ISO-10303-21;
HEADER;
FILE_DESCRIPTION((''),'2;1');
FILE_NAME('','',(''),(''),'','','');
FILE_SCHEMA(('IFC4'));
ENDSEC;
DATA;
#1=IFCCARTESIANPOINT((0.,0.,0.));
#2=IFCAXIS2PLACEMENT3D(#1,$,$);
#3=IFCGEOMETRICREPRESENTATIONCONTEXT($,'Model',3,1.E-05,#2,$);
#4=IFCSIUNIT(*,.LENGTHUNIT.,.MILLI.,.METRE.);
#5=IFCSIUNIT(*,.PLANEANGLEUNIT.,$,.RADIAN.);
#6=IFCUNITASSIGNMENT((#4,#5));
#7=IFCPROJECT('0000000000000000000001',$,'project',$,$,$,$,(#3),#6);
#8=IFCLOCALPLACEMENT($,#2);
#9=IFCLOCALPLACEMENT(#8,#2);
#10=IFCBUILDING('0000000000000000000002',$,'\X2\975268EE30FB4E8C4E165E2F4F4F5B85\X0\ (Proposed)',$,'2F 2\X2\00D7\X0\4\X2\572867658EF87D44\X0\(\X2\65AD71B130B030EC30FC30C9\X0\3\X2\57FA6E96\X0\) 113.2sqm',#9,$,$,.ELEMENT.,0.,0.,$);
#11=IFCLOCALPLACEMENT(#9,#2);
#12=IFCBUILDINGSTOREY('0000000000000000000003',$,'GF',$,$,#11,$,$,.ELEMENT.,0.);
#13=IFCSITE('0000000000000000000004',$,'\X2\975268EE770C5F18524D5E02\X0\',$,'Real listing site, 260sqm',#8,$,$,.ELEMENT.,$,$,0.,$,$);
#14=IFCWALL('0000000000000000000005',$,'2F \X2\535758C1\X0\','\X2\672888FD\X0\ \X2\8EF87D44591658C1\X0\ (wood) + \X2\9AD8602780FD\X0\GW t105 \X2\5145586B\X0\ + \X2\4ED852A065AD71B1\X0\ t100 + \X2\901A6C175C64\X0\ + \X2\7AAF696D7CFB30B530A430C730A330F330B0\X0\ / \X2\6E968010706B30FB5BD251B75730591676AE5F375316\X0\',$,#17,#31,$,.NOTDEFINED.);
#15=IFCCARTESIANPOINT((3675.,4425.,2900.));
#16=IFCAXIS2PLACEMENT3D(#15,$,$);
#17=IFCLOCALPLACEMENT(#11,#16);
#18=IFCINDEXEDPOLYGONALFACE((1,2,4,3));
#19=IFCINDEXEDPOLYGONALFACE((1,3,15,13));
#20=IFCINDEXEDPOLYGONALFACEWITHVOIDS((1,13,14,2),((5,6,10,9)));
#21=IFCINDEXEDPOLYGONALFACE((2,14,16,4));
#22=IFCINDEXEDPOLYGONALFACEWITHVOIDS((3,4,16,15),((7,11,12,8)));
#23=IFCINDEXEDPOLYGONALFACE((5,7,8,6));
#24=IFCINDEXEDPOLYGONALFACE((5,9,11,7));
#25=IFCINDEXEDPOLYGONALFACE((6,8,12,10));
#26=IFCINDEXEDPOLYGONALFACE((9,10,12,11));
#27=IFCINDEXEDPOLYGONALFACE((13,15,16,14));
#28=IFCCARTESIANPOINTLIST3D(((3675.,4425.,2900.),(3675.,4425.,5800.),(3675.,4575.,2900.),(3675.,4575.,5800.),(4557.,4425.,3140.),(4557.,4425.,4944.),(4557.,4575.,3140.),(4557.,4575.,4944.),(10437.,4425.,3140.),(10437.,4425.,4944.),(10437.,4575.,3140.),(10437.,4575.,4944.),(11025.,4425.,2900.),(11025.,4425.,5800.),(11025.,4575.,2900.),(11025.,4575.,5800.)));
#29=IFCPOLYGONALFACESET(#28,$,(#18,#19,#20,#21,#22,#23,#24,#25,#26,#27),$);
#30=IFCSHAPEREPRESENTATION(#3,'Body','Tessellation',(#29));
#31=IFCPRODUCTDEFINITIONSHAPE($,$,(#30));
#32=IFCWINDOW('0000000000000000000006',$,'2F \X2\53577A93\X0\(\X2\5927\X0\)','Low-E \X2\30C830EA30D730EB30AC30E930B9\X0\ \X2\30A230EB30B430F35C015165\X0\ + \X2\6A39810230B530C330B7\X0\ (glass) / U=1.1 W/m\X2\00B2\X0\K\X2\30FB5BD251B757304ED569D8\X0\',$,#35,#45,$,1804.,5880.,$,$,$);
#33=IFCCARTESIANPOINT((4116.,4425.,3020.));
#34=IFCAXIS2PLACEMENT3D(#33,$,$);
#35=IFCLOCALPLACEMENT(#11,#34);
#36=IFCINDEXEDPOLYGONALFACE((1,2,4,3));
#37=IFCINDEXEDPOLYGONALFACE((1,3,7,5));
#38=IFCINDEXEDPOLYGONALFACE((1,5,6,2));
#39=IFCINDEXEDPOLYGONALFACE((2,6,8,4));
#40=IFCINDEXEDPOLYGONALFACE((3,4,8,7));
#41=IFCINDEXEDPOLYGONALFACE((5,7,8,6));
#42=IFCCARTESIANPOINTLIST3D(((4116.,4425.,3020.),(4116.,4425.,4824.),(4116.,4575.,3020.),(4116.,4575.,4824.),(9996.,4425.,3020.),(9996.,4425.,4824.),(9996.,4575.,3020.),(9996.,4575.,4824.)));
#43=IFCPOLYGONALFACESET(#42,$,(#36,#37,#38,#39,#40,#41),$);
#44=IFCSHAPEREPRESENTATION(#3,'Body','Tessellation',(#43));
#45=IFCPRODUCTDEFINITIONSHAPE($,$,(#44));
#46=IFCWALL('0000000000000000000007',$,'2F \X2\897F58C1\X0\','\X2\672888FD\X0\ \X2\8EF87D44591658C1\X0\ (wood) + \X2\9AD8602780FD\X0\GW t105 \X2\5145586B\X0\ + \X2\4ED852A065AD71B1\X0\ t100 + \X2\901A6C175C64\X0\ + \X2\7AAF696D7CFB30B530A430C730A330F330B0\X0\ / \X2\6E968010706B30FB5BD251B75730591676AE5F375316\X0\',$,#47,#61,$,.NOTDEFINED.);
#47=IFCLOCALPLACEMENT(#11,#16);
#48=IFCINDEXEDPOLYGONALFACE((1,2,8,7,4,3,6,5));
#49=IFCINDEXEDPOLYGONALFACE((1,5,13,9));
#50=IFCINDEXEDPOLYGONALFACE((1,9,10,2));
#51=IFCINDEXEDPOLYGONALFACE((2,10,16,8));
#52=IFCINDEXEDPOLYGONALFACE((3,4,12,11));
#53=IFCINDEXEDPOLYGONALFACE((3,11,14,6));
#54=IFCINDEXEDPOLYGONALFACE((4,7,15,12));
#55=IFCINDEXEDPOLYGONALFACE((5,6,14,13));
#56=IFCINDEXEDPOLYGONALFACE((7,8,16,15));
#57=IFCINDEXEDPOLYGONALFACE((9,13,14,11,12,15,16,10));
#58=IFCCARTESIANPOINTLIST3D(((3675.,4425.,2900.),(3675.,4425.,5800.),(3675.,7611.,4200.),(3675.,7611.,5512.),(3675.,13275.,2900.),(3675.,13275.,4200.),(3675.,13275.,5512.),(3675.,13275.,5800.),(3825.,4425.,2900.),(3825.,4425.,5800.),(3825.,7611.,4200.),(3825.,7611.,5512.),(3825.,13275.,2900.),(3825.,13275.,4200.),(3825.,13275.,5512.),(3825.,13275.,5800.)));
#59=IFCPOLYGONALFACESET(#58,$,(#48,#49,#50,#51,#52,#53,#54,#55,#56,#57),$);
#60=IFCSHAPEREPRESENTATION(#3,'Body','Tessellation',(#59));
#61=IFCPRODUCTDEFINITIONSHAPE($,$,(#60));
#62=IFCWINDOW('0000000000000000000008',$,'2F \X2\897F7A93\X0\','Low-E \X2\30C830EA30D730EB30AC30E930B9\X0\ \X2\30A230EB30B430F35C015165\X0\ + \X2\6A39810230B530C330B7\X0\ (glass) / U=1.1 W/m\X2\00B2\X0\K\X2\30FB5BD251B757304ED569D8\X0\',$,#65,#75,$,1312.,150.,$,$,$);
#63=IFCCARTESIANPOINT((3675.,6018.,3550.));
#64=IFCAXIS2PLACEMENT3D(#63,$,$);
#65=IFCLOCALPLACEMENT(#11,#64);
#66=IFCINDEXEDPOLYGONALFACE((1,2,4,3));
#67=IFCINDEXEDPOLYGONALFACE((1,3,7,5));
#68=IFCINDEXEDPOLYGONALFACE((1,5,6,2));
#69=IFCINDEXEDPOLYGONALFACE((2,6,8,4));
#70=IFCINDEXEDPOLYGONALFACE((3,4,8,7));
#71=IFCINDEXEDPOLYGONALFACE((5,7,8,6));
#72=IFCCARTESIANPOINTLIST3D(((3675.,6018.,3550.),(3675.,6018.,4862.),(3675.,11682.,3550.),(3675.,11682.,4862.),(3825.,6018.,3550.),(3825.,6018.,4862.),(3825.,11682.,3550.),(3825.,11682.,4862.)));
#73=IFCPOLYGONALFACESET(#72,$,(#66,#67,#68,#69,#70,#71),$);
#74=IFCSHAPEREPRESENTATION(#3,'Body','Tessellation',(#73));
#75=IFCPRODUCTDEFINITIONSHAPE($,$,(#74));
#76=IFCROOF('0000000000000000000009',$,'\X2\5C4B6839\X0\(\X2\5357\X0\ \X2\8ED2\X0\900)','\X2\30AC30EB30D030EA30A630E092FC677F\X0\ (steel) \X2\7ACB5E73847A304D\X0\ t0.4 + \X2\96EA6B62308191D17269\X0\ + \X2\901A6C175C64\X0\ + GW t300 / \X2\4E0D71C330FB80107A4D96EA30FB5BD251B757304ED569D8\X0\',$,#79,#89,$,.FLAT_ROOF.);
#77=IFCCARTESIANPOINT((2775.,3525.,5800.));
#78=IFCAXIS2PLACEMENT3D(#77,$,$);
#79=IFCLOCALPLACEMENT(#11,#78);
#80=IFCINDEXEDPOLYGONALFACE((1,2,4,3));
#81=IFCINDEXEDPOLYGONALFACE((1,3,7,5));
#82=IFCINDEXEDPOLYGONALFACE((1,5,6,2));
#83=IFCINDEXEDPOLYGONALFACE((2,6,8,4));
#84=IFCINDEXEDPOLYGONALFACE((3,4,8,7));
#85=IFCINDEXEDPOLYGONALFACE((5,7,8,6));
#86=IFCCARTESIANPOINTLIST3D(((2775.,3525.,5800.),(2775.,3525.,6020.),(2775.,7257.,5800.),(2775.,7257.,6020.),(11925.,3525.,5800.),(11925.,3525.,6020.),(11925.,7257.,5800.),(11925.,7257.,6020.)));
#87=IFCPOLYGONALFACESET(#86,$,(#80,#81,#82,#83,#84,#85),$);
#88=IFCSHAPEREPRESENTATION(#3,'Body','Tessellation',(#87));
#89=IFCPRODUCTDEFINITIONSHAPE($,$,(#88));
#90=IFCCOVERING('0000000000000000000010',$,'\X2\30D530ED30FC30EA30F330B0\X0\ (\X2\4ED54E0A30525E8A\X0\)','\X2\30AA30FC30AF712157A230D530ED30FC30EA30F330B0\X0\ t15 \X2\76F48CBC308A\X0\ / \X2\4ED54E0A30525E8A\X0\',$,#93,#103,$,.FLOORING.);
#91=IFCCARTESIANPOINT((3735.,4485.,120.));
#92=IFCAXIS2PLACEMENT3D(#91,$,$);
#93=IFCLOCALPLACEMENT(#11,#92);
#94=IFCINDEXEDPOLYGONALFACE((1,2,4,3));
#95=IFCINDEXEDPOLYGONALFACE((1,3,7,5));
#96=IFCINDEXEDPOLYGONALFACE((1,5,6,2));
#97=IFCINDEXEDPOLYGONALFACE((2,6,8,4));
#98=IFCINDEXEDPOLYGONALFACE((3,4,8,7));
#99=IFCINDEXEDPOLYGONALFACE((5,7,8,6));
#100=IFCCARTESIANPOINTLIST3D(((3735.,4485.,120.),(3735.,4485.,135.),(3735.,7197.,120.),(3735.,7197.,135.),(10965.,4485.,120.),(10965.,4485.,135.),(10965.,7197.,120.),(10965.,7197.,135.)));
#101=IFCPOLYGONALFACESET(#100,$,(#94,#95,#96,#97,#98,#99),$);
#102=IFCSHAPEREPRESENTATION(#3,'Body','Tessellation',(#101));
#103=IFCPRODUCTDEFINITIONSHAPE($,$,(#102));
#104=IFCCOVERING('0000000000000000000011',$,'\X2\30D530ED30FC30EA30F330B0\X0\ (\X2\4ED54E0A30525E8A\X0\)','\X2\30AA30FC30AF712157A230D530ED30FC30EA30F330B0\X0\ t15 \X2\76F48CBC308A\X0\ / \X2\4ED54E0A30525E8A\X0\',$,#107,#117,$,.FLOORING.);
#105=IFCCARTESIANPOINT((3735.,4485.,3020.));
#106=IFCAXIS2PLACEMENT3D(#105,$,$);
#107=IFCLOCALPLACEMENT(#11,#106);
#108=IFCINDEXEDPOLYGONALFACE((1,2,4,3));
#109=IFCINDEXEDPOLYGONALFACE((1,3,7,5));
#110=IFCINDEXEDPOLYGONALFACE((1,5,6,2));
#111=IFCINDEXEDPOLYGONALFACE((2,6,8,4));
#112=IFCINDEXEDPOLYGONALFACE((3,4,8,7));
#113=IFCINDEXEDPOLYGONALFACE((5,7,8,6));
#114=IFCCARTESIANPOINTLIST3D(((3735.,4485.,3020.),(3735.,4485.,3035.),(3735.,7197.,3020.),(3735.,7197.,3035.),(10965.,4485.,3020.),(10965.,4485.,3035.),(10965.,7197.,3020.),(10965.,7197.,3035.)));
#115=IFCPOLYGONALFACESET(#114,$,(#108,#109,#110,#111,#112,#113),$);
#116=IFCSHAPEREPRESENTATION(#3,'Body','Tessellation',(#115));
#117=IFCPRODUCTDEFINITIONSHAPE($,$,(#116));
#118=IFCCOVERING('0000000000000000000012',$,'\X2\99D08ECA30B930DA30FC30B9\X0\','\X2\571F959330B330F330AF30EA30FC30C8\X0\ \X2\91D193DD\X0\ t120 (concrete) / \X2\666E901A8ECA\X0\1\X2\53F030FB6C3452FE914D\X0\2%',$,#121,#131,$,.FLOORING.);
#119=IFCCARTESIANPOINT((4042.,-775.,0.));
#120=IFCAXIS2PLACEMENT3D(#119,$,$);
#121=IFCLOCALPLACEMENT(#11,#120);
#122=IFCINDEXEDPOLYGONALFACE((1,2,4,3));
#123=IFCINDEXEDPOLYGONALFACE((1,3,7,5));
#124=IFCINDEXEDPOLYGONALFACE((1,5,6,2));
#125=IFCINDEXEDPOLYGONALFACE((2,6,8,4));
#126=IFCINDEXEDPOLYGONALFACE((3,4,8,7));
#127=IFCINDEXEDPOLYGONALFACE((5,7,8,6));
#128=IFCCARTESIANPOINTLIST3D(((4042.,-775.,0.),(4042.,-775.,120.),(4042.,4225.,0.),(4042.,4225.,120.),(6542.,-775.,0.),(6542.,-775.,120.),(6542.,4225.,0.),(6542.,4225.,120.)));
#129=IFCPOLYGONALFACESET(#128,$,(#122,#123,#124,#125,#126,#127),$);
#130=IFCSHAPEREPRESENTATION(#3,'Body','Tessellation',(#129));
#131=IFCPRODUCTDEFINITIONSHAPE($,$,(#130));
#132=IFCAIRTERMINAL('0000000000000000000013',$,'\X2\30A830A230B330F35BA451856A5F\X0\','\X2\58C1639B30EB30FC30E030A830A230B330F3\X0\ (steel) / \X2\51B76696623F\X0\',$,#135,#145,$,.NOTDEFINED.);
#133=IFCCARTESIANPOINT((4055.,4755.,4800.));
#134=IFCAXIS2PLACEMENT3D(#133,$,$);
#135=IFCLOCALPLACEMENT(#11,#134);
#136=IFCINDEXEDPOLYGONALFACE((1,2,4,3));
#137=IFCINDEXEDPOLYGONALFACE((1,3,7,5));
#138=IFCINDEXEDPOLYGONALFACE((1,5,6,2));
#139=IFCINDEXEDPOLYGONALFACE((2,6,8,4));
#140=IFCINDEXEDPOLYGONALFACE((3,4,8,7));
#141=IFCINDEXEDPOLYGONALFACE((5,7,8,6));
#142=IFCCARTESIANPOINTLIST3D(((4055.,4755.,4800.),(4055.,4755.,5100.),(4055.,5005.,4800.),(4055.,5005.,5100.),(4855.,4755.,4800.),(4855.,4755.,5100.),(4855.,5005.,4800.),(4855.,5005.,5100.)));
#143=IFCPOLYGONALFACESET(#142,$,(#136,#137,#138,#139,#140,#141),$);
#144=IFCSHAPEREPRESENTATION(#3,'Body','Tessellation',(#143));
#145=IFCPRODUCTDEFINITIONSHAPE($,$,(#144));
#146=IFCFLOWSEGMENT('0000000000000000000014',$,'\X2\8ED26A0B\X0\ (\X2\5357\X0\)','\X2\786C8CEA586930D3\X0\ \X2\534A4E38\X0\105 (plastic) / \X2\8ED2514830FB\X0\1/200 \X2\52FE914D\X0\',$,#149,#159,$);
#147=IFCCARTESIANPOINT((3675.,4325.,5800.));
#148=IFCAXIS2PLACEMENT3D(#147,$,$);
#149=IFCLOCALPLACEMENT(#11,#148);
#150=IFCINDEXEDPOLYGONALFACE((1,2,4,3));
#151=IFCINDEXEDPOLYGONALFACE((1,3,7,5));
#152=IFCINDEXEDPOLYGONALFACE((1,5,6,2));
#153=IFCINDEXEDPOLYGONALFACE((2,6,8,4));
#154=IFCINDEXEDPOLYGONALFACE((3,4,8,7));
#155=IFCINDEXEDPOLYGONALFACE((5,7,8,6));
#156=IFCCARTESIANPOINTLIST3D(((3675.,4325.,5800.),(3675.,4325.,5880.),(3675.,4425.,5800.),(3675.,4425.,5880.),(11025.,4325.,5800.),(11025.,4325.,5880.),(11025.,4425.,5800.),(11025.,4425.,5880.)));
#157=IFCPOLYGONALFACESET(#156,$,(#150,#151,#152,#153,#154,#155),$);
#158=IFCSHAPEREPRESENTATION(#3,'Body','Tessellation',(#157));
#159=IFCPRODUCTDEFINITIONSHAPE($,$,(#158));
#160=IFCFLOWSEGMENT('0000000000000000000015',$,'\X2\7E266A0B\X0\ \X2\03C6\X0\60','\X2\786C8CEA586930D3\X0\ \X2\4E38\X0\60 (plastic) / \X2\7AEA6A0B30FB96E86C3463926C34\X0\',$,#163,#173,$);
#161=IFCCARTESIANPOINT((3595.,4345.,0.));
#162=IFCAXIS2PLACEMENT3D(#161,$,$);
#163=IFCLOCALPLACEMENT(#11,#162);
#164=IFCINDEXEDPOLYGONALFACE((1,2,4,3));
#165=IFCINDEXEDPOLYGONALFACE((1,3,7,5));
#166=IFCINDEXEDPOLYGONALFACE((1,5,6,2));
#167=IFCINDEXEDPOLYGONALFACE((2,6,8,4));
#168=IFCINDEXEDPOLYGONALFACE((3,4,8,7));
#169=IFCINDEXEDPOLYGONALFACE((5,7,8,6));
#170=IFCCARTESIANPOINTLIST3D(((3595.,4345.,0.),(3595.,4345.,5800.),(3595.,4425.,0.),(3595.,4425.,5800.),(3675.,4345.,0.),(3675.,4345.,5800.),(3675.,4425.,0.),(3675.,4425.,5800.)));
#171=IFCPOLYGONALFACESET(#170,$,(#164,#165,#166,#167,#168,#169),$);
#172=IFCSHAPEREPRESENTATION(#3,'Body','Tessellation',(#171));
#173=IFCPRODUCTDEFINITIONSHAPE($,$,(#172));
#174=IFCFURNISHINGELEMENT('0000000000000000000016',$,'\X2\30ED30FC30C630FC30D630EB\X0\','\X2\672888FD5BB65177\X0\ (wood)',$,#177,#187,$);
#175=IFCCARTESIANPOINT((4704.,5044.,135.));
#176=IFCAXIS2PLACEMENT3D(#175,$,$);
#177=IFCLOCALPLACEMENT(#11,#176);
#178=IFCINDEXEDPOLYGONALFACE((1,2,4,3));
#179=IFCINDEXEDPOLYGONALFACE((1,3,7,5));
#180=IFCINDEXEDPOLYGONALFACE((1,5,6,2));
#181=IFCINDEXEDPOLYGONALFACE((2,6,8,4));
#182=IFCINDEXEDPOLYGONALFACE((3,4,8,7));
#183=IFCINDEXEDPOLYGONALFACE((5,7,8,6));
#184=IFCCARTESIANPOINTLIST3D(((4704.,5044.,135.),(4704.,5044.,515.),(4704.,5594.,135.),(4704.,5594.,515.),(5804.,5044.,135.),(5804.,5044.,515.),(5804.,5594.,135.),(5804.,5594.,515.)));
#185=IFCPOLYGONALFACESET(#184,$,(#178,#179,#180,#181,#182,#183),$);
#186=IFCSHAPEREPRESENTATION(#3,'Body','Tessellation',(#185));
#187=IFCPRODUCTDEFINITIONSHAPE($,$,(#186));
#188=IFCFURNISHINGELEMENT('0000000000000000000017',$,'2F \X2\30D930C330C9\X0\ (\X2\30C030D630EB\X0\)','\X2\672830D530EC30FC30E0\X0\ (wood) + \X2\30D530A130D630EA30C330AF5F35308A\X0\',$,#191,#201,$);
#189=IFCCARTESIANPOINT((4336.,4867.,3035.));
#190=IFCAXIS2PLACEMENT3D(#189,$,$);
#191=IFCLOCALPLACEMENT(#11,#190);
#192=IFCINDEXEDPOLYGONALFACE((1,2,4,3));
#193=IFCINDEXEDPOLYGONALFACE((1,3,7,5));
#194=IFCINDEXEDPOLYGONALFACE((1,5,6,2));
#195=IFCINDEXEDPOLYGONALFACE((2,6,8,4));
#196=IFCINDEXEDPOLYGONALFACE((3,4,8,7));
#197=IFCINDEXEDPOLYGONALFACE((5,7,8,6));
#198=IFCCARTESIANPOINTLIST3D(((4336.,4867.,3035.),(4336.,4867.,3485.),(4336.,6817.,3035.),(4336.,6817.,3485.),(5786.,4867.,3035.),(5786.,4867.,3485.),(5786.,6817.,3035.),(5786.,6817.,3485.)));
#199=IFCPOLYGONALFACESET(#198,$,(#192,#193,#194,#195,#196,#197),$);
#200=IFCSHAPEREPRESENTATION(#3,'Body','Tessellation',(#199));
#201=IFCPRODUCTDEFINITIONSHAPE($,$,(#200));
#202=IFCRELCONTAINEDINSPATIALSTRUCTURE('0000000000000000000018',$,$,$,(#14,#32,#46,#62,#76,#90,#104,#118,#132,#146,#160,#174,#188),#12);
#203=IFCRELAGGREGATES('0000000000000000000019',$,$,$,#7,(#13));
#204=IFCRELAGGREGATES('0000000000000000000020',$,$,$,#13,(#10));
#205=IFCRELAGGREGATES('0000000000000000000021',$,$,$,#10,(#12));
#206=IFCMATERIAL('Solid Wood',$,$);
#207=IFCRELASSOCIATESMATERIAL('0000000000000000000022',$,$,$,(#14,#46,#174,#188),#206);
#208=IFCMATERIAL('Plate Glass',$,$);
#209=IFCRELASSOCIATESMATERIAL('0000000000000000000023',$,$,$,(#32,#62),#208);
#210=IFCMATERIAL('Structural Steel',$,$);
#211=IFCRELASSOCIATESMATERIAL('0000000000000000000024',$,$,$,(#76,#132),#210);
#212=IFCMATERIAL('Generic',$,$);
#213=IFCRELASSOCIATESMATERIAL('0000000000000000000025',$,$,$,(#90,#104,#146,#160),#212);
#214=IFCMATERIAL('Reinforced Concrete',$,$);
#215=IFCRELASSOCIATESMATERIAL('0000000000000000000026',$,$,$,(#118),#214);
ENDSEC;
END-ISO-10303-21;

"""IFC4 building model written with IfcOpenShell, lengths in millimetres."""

from ifc_helpers import new_model, si_unit, frame, frame_2d, origin, place, context, project, spatial, rectangle, extrude, material, element, fill, save


model = new_model("IFC4")

# Units and contexts
model_context = context("Model", 3, precision=1e-05, world=origin())
ifc_project = project(units=[si_unit("LENGTHUNIT", "METRE", prefix="MILLI"), si_unit("PLANEANGLEUNIT", "RADIAN")], contexts=[model_context])

# Site, building, storey
site_placement = place(None, origin())
site = spatial("IfcSite", under=ifc_project, at=site_placement, Name="青森県弘前市", ObjectType="Real listing site, 260sqm", CompositionType="ELEMENT", RefElevation=0.0)
building_placement = place(site_placement, origin())
building = spatial("IfcBuilding", under=site, at=building_placement, Name="青森・二世帯住宅 (Proposed)", ObjectType="2F 2×4在来軸組(断熱グレード3基準) 113.2sqm", CompositionType="ELEMENT", ElevationOfRefHeight=0.0, ElevationOfTerrain=0.0)
storey_placement = place(building_placement, origin())
storey = spatial("IfcBuildingStorey", under=building, at=storey_placement, Name="GF", CompositionType="ELEMENT", Elevation=0.0)

# Shared definitions
ifc_material_1 = material(Name="Solid Wood")

# Shared definitions
ifc_material_2 = material(Name="Reinforced Concrete")

# Shared definitions
ifc_material_3 = material(Name="Plate Glass")

# Walls, openings, windows
wall_1_placement = place(storey_placement, frame((3675.0, 4425.0, 2900.0)))
wall_1 = element("IfcWall", 1, at=wall_1_placement, inside=storey, material=ifc_material_1, Name="2F 南壁", Description="木製 軸組外壁 (wood) + 高性能GW t105 充填 + 付加断熱 t100 + 通気層 + 窯業系サイディング / 準耐火・寒冷地外皮強化", PredefinedType="NOTDEFINED", context=model_context, shape_type="SweptSolid", body=[
    extrude(rectangle(XDim=7350.0, YDim=150.0, at=frame_2d((3675.0, 75.0))), frame((3675.0, 4425.0, 2900.0)), (0.0, 0.0, 1.0), 2900.0),
])
opening_1_placement = place(storey_placement, frame((4116.0, 4425.0, 3020.0)))
opening_1 = element("IfcOpeningElement", 2, at=opening_1_placement, cuts=wall_1, PredefinedType="NOTDEFINED", context=model_context, shape_type="SweptSolid", body=[
    extrude(rectangle(XDim=5880.0, YDim=150.0, at=frame_2d((2940.0, 75.0))), frame((4116.0, 4425.0, 3020.0)), (0.0, 0.0, 1.0), 1804.0),
])
window_1_placement = place(storey_placement, frame((4116.0, 4425.0, 3020.0)))
window_1 = element("IfcWindow", 3, at=window_1_placement, inside=storey, material=ifc_material_3, Name="2F 南窓(大)", Description="Low-E トリプルガラス アルゴン封入 + 樹脂サッシ (glass) / U=1.1 W/m²K・寒冷地仕様", OverallHeight=1804.0, OverallWidth=5880.0, context=model_context, shape_type="SweptSolid", body=[
    extrude(rectangle(XDim=5880.0, YDim=150.0, at=frame_2d((2940.0, 75.0))), frame((4116.0, 4425.0, 3020.0)), (0.0, 0.0, 1.0), 1804.0),
])
fill(opening_1, window_1)
wall_2_placement = place(storey_placement, frame((3675.0, 4425.0, 2900.0)))
wall_2 = element("IfcWall", 4, at=wall_2_placement, inside=storey, material=ifc_material_1, Name="2F 西壁", Description="木製 軸組外壁 (wood) + 高性能GW t105 充填 + 付加断熱 t100 + 通気層 + 窯業系サイディング / 準耐火・寒冷地外皮強化", PredefinedType="NOTDEFINED", context=model_context, shape_type="SweptSolid", body=[
    extrude(rectangle(XDim=150.0, YDim=8850.0, at=frame_2d((75.0, 4425.0))), frame((3675.0, 4425.0, 2900.0)), (0.0, 0.0, 1.0), 2900.0),
])
opening_2_placement = place(storey_placement, frame((3675.0, 6018.0, 3550.0)))
opening_2 = element("IfcOpeningElement", 5, at=opening_2_placement, cuts=wall_2, PredefinedType="NOTDEFINED", context=model_context, shape_type="SweptSolid", body=[
    extrude(rectangle(XDim=150.0, YDim=5664.0, at=frame_2d((75.0, 2832.0))), frame((3675.0, 6018.0, 3550.0)), (0.0, 0.0, 1.0), 1312.0),
])
window_2_placement = place(storey_placement, frame((3675.0, 6018.0, 3550.0)))
window_2 = element("IfcWindow", 6, at=window_2_placement, inside=storey, material=ifc_material_3, Name="2F 西窓", Description="Low-E トリプルガラス アルゴン封入 + 樹脂サッシ (glass) / U=1.1 W/m²K・寒冷地仕様", OverallHeight=1312.0, OverallWidth=150.0, context=model_context, shape_type="SweptSolid", body=[
    extrude(rectangle(XDim=150.0, YDim=5664.0, at=frame_2d((75.0, 2832.0))), frame((3675.0, 6018.0, 3550.0)), (0.0, 0.0, 1.0), 1312.0),
])
fill(opening_2, window_2)

# Roof
ifc_material_4 = material(Name="Structural Steel")
for number, where, name in (
    (7, (2775.0, 3525.0, 5800.0), "屋根(南 軒900)"),
):
    element("IfcRoof", number, at=place(storey_placement, frame(where)), inside=storey, material=ifc_material_4, Name=name, Description="ガルバリウム鋼板 (steel) 立平葺き t0.4 + 雪止め金物 + 通気層 + GW t300 / 不燃・耐積雪・寒冷地仕様", PredefinedType="FLAT_ROOF", context=model_context, shape_type="SweptSolid", body=[
        extrude(rectangle(XDim=9150.0, YDim=3732.0, at=frame_2d((4575.0, 1866.0))), frame((2775.0, 3525.0, 5800.0)), (0.0, 0.0, 1.0), 220.0),
    ])

# Coverings
ifc_material_5 = material(Name="Generic")
covering_1_placement = place(storey_placement, frame((3735.0, 4485.0, 120.0)))
element("IfcCovering", 8, at=covering_1_placement, inside=storey, material=ifc_material_5, Name="フローリング (仕上げ床)", Description="オーク無垢フローリング t15 直貼り / 仕上げ床", PredefinedType="FLOORING", context=model_context, shape_type="SweptSolid", body=[
    extrude(rectangle(XDim=7230.0, YDim=2712.0, at=frame_2d((3615.0, 1356.0))), frame((3735.0, 4485.0, 120.0)), (0.0, 0.0, 1.0), 15.0),
])
covering_2_placement = place(storey_placement, frame((3735.0, 4485.0, 3020.0)))
element("IfcCovering", 9, at=covering_2_placement, inside=storey, material=ifc_material_5, Name="フローリング (仕上げ床)", Description="オーク無垢フローリング t15 直貼り / 仕上げ床", PredefinedType="FLOORING", context=model_context, shape_type="SweptSolid", body=[
    extrude(rectangle(XDim=7230.0, YDim=2712.0, at=frame_2d((3615.0, 1356.0))), frame((3735.0, 4485.0, 3020.0)), (0.0, 0.0, 1.0), 15.0),
])
covering_3_placement = place(storey_placement, frame((4042.0, -775.0, 0.0)))
element("IfcCovering", 10, at=covering_3_placement, inside=storey, material=ifc_material_2, Name="駐車スペース", Description="土間コンクリート 金鏝 t120 (concrete) / 普通車1台・水勾配2%", PredefinedType="FLOORING", context=model_context, shape_type="SweptSolid", body=[
    extrude(rectangle(XDim=2500.0, YDim=5000.0, at=frame_2d((1250.0, 2500.0))), frame((4042.0, -775.0, 0.0)), (0.0, 0.0, 1.0), 120.0),
])

# Air terminal
air_terminal_placement = place(storey_placement, frame((4055.0, 4755.0, 4800.0)))
element("IfcAirTerminal", 11, at=air_terminal_placement, inside=storey, material=ifc_material_4, Name="エアコン室内機", Description="壁掛ルームエアコン (steel) / 冷暖房", PredefinedType="NOTDEFINED", context=model_context, shape_type="SweptSolid", body=[
    extrude(rectangle(XDim=800.0, YDim=250.0, at=frame_2d((400.0, 125.0))), frame((4055.0, 4755.0, 4800.0)), (0.0, 0.0, 1.0), 300.0),
])

# Flow segments
flow_segment_1_placement = place(storey_placement, frame((3675.0, 4325.0, 5800.0)))
element("IfcFlowSegment", 12, at=flow_segment_1_placement, inside=storey, material=ifc_material_5, Name="軒樋 (南)", Description="硬質塩ビ 半丸105 (plastic) / 軒先・1/200 勾配", context=model_context, shape_type="SweptSolid", body=[
    extrude(rectangle(XDim=7350.0, YDim=100.0, at=frame_2d((3675.0, 50.0))), frame((3675.0, 4325.0, 5800.0)), (0.0, 0.0, 1.0), 80.0),
])
flow_segment_2_placement = place(storey_placement, frame((3595.0, 4345.0, 0.0)))
element("IfcFlowSegment", 13, at=flow_segment_2_placement, inside=storey, material=ifc_material_5, Name="縦樋 φ60", Description="硬質塩ビ 丸60 (plastic) / 竪樋・雨水排水", context=model_context, shape_type="SweptSolid", body=[
    extrude(rectangle(XDim=80.0, YDim=80.0, at=frame_2d((40.0, 40.0))), frame((3595.0, 4345.0, 0.0)), (0.0, 0.0, 1.0), 5800.0),
])

# Furnishing elements
furnishing_1_placement = place(storey_placement, frame((4704.0, 5044.0, 135.0)))
element("IfcFurnishingElement", 14, at=furnishing_1_placement, inside=storey, material=ifc_material_1, Name="ローテーブル", Description="木製家具 (wood)", context=model_context, shape_type="SweptSolid", body=[
    extrude(rectangle(XDim=1100.0, YDim=550.0, at=frame_2d((550.0, 275.0))), frame((4704.0, 5044.0, 135.0)), (0.0, 0.0, 1.0), 380.0),
])
furnishing_2_placement = place(storey_placement, frame((4336.0, 4867.0, 3035.0)))
element("IfcFurnishingElement", 15, at=furnishing_2_placement, inside=storey, material=ifc_material_1, Name="2F ベッド (ダブル)", Description="木フレーム (wood) + ファブリック張り", context=model_context, shape_type="SweptSolid", body=[
    extrude(rectangle(XDim=1450.0, YDim=1950.0, at=frame_2d((725.0, 975.0))), frame((4336.0, 4867.0, 3035.0)), (0.0, 0.0, 1.0), 450.0),
])

save(model, "model.ifc")
